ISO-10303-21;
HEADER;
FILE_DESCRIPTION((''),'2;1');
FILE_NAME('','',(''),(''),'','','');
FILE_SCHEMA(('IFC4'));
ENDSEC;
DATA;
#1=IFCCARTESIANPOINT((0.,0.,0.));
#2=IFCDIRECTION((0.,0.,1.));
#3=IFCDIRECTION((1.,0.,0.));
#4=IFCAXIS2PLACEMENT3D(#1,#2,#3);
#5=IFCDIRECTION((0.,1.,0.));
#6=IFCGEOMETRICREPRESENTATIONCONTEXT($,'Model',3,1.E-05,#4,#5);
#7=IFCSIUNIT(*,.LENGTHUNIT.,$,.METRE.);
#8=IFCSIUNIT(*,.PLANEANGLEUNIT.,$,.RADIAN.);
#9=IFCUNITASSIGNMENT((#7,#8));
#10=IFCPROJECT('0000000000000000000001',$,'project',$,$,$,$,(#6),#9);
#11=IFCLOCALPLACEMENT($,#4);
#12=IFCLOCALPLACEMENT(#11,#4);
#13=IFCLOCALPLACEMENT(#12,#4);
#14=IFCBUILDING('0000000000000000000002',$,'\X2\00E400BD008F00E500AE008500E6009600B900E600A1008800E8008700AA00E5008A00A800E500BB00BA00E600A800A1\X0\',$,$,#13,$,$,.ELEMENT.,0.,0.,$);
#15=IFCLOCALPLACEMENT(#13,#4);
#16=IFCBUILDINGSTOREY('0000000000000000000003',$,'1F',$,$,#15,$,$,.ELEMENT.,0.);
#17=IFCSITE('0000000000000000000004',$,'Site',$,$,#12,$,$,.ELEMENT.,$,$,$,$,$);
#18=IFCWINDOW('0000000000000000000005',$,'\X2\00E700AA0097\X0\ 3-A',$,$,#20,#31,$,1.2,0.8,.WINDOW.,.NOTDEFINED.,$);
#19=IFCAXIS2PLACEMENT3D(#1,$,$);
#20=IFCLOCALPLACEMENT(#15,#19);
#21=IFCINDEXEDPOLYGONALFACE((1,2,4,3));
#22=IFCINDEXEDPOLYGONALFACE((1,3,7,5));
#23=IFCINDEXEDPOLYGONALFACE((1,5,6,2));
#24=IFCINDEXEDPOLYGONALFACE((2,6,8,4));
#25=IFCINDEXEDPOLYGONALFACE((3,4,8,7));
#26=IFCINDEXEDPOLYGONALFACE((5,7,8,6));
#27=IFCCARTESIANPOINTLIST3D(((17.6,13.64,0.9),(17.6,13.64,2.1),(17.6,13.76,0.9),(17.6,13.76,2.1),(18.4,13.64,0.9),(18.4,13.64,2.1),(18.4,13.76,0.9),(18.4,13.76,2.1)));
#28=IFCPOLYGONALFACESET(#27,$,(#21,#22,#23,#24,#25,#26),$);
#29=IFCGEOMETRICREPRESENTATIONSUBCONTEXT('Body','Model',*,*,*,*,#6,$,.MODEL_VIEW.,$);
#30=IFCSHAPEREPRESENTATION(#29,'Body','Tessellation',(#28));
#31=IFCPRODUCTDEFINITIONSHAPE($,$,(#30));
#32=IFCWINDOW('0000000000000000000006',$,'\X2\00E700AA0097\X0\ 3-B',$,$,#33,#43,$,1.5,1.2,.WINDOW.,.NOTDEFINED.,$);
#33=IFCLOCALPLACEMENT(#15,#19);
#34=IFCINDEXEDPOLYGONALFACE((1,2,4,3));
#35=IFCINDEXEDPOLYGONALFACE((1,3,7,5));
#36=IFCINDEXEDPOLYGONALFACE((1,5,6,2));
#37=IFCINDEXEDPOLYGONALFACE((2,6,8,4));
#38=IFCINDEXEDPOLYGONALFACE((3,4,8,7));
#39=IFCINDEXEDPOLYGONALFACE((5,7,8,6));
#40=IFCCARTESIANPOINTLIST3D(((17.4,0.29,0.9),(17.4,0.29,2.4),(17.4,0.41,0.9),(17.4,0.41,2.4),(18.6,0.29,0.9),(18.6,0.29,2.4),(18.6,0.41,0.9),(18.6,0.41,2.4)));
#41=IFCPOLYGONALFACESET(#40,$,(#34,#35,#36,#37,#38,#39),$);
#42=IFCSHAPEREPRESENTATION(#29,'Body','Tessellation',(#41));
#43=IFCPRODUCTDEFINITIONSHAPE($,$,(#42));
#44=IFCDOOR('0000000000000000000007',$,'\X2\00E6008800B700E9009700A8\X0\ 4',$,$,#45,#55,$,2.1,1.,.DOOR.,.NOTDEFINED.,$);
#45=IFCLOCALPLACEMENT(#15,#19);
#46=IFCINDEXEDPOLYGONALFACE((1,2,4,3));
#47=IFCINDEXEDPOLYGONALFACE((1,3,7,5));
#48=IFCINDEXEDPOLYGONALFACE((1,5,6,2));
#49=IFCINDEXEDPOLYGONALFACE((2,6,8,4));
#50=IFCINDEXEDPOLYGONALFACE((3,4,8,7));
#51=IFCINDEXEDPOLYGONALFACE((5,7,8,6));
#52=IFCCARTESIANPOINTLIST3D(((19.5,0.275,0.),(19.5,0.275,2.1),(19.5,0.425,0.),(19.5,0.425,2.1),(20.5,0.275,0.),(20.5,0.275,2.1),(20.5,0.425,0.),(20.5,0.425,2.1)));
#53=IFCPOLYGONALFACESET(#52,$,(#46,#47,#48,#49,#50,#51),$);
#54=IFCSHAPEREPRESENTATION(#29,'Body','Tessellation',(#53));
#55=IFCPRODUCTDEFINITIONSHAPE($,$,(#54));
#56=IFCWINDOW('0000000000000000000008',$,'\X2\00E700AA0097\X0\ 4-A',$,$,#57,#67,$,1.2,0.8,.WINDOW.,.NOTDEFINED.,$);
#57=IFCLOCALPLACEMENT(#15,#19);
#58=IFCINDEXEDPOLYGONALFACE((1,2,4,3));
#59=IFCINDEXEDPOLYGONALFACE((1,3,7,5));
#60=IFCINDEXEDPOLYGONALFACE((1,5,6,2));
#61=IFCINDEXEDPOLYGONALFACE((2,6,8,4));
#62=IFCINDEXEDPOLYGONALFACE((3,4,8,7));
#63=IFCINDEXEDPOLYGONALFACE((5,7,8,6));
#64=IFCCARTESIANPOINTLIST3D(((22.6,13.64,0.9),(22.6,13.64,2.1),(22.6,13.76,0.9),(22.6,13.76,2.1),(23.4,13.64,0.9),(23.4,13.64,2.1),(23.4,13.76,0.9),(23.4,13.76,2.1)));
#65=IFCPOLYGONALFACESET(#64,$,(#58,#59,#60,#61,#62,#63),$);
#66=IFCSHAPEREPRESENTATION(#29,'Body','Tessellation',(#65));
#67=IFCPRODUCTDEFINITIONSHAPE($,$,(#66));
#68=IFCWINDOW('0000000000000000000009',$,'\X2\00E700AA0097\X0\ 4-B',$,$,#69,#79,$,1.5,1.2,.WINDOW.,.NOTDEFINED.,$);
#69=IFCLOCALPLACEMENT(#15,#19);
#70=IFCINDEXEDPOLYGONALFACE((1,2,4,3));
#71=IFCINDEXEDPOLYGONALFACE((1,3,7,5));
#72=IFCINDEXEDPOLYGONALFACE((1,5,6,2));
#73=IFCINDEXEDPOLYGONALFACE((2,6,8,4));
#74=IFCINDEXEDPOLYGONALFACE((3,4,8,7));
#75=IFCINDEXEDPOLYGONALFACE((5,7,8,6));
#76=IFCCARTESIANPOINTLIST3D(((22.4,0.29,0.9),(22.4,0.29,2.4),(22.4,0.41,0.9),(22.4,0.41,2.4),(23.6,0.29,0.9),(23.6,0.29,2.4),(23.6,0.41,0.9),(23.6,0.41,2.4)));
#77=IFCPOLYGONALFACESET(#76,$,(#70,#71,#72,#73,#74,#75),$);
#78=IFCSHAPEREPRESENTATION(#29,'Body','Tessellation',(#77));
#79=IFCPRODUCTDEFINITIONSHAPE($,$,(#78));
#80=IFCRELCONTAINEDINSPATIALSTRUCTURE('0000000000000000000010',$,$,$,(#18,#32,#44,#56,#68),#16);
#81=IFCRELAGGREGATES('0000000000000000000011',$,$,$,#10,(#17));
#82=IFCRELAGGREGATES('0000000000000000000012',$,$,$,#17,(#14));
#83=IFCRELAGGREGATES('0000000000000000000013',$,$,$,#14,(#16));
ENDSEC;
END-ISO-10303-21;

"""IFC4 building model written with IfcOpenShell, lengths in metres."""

from ifc_helpers import new_model, si_unit, direction, frame, frame_2d, origin_with_axes, place, context, subcontext, project, spatial, rectangle, extrude, element, save


model = new_model("IFC4")

# Units and contexts
model_context = context("Model", 3, precision=1e-05, world=origin_with_axes(), true_north=direction((0.0, 1.0, 0.0)))
body_context = subcontext(model_context, "Body", "Model", "MODEL_VIEW")
ifc_project = project(units=[si_unit("LENGTHUNIT", "METRE"), si_unit("PLANEANGLEUNIT", "RADIAN")], contexts=[model_context])

# Site, building, storey
placement = place(None, origin_with_axes())
site_placement = place(placement, origin_with_axes())
site = spatial("IfcSite", under=ifc_project, at=site_placement, Name="Site", CompositionType="ELEMENT")
building_placement = place(site_placement, origin_with_axes())
building = spatial("IfcBuilding", under=site, at=building_placement, Name="ä½\u008få®\u0085æ\u0096¹æ¡\u0088è\u0087ªå\u008a¨å»ºæ¨¡", CompositionType="ELEMENT", ElevationOfRefHeight=0.0, ElevationOfTerrain=0.0)
storey_placement = place(building_placement, origin_with_axes())
storey = spatial("IfcBuildingStorey", under=building, at=storey_placement, Name="1F", CompositionType="ELEMENT", Elevation=0.0)

# Windows
window_1_placement = place(storey_placement, frame((18.0, 13.7, 0.9), z_axis=(0.0, 0.0, 1.0), x_axis=(1.0, 0.0, 0.0)))
element("IfcWindow", 1, at=window_1_placement, inside=storey, Name="çª\u0097 3-A", OverallHeight=1.2, OverallWidth=0.8, PartitioningType="NOTDEFINED", PredefinedType="WINDOW", context=body_context, shape_type="SweptSolid", body=[
    extrude(rectangle(XDim=0.8, YDim=0.12, at=frame_2d((0.0, 0.0), x_axis=(1.0, 0.0, 0.0))), frame((0.0, 0.0, 0.0), z_axis=(0.0, 0.0, 1.0)), (0.0, 0.0, 1.0), 1.2),
])
window_2_placement = place(storey_placement, frame((18.0, 0.35, 0.9), z_axis=(0.0, 0.0, 1.0), x_axis=(1.0, 0.0, 0.0)))
element("IfcWindow", 2, at=window_2_placement, inside=storey, Name="çª\u0097 3-B", OverallHeight=1.5, OverallWidth=1.2, PartitioningType="NOTDEFINED", PredefinedType="WINDOW", context=body_context, shape_type="SweptSolid", body=[
    extrude(rectangle(XDim=1.2, YDim=0.12, at=frame_2d((0.0, 0.0), x_axis=(1.0, 0.0, 0.0))), frame((0.0, 0.0, 0.0), z_axis=(0.0, 0.0, 1.0)), (0.0, 0.0, 1.0), 1.5),
])

# Door
door_1_placement = place(storey_placement, frame((20.0, 0.35, 0.0), z_axis=(0.0, 0.0, 1.0), x_axis=(1.0, 0.0, 0.0)))
element("IfcDoor", 3, at=door_1_placement, inside=storey, Name="æ\u0088·é\u0097¨ 4", OperationType="NOTDEFINED", OverallHeight=2.1, OverallWidth=1.0, PredefinedType="DOOR", context=body_context, shape_type="SweptSolid", body=[
    extrude(rectangle(XDim=1.0, YDim=0.15, at=frame_2d((0.0, 0.0), x_axis=(1.0, 0.0, 0.0))), frame((0.0, 0.0, 0.0), z_axis=(0.0, 0.0, 1.0)), (0.0, 0.0, 1.0), 2.1),
])

# Windows
window_3_placement = place(storey_placement, frame((23.0, 13.7, 0.9), z_axis=(0.0, 0.0, 1.0), x_axis=(1.0, 0.0, 0.0)))
element("IfcWindow", 4, at=window_3_placement, inside=storey, Name="çª\u0097 4-A", OverallHeight=1.2, OverallWidth=0.8, PartitioningType="NOTDEFINED", PredefinedType="WINDOW", context=body_context, shape_type="SweptSolid", body=[
    extrude(rectangle(XDim=0.8, YDim=0.12, at=frame_2d((0.0, 0.0), x_axis=(1.0, 0.0, 0.0))), frame((0.0, 0.0, 0.0), z_axis=(0.0, 0.0, 1.0)), (0.0, 0.0, 1.0), 1.2),
])
window_4_placement = place(storey_placement, frame((23.0, 0.35, 0.9), z_axis=(0.0, 0.0, 1.0), x_axis=(1.0, 0.0, 0.0)))
element("IfcWindow", 5, at=window_4_placement, inside=storey, Name="çª\u0097 4-B", OverallHeight=1.5, OverallWidth=1.2, PartitioningType="NOTDEFINED", PredefinedType="WINDOW", context=body_context, shape_type="SweptSolid", body=[
    extrude(rectangle(XDim=1.2, YDim=0.12, at=frame_2d((0.0, 0.0), x_axis=(1.0, 0.0, 0.0))), frame((0.0, 0.0, 0.0), z_axis=(0.0, 0.0, 1.0)), (0.0, 0.0, 1.0), 1.5),
])

save(model, "model.ifc")
